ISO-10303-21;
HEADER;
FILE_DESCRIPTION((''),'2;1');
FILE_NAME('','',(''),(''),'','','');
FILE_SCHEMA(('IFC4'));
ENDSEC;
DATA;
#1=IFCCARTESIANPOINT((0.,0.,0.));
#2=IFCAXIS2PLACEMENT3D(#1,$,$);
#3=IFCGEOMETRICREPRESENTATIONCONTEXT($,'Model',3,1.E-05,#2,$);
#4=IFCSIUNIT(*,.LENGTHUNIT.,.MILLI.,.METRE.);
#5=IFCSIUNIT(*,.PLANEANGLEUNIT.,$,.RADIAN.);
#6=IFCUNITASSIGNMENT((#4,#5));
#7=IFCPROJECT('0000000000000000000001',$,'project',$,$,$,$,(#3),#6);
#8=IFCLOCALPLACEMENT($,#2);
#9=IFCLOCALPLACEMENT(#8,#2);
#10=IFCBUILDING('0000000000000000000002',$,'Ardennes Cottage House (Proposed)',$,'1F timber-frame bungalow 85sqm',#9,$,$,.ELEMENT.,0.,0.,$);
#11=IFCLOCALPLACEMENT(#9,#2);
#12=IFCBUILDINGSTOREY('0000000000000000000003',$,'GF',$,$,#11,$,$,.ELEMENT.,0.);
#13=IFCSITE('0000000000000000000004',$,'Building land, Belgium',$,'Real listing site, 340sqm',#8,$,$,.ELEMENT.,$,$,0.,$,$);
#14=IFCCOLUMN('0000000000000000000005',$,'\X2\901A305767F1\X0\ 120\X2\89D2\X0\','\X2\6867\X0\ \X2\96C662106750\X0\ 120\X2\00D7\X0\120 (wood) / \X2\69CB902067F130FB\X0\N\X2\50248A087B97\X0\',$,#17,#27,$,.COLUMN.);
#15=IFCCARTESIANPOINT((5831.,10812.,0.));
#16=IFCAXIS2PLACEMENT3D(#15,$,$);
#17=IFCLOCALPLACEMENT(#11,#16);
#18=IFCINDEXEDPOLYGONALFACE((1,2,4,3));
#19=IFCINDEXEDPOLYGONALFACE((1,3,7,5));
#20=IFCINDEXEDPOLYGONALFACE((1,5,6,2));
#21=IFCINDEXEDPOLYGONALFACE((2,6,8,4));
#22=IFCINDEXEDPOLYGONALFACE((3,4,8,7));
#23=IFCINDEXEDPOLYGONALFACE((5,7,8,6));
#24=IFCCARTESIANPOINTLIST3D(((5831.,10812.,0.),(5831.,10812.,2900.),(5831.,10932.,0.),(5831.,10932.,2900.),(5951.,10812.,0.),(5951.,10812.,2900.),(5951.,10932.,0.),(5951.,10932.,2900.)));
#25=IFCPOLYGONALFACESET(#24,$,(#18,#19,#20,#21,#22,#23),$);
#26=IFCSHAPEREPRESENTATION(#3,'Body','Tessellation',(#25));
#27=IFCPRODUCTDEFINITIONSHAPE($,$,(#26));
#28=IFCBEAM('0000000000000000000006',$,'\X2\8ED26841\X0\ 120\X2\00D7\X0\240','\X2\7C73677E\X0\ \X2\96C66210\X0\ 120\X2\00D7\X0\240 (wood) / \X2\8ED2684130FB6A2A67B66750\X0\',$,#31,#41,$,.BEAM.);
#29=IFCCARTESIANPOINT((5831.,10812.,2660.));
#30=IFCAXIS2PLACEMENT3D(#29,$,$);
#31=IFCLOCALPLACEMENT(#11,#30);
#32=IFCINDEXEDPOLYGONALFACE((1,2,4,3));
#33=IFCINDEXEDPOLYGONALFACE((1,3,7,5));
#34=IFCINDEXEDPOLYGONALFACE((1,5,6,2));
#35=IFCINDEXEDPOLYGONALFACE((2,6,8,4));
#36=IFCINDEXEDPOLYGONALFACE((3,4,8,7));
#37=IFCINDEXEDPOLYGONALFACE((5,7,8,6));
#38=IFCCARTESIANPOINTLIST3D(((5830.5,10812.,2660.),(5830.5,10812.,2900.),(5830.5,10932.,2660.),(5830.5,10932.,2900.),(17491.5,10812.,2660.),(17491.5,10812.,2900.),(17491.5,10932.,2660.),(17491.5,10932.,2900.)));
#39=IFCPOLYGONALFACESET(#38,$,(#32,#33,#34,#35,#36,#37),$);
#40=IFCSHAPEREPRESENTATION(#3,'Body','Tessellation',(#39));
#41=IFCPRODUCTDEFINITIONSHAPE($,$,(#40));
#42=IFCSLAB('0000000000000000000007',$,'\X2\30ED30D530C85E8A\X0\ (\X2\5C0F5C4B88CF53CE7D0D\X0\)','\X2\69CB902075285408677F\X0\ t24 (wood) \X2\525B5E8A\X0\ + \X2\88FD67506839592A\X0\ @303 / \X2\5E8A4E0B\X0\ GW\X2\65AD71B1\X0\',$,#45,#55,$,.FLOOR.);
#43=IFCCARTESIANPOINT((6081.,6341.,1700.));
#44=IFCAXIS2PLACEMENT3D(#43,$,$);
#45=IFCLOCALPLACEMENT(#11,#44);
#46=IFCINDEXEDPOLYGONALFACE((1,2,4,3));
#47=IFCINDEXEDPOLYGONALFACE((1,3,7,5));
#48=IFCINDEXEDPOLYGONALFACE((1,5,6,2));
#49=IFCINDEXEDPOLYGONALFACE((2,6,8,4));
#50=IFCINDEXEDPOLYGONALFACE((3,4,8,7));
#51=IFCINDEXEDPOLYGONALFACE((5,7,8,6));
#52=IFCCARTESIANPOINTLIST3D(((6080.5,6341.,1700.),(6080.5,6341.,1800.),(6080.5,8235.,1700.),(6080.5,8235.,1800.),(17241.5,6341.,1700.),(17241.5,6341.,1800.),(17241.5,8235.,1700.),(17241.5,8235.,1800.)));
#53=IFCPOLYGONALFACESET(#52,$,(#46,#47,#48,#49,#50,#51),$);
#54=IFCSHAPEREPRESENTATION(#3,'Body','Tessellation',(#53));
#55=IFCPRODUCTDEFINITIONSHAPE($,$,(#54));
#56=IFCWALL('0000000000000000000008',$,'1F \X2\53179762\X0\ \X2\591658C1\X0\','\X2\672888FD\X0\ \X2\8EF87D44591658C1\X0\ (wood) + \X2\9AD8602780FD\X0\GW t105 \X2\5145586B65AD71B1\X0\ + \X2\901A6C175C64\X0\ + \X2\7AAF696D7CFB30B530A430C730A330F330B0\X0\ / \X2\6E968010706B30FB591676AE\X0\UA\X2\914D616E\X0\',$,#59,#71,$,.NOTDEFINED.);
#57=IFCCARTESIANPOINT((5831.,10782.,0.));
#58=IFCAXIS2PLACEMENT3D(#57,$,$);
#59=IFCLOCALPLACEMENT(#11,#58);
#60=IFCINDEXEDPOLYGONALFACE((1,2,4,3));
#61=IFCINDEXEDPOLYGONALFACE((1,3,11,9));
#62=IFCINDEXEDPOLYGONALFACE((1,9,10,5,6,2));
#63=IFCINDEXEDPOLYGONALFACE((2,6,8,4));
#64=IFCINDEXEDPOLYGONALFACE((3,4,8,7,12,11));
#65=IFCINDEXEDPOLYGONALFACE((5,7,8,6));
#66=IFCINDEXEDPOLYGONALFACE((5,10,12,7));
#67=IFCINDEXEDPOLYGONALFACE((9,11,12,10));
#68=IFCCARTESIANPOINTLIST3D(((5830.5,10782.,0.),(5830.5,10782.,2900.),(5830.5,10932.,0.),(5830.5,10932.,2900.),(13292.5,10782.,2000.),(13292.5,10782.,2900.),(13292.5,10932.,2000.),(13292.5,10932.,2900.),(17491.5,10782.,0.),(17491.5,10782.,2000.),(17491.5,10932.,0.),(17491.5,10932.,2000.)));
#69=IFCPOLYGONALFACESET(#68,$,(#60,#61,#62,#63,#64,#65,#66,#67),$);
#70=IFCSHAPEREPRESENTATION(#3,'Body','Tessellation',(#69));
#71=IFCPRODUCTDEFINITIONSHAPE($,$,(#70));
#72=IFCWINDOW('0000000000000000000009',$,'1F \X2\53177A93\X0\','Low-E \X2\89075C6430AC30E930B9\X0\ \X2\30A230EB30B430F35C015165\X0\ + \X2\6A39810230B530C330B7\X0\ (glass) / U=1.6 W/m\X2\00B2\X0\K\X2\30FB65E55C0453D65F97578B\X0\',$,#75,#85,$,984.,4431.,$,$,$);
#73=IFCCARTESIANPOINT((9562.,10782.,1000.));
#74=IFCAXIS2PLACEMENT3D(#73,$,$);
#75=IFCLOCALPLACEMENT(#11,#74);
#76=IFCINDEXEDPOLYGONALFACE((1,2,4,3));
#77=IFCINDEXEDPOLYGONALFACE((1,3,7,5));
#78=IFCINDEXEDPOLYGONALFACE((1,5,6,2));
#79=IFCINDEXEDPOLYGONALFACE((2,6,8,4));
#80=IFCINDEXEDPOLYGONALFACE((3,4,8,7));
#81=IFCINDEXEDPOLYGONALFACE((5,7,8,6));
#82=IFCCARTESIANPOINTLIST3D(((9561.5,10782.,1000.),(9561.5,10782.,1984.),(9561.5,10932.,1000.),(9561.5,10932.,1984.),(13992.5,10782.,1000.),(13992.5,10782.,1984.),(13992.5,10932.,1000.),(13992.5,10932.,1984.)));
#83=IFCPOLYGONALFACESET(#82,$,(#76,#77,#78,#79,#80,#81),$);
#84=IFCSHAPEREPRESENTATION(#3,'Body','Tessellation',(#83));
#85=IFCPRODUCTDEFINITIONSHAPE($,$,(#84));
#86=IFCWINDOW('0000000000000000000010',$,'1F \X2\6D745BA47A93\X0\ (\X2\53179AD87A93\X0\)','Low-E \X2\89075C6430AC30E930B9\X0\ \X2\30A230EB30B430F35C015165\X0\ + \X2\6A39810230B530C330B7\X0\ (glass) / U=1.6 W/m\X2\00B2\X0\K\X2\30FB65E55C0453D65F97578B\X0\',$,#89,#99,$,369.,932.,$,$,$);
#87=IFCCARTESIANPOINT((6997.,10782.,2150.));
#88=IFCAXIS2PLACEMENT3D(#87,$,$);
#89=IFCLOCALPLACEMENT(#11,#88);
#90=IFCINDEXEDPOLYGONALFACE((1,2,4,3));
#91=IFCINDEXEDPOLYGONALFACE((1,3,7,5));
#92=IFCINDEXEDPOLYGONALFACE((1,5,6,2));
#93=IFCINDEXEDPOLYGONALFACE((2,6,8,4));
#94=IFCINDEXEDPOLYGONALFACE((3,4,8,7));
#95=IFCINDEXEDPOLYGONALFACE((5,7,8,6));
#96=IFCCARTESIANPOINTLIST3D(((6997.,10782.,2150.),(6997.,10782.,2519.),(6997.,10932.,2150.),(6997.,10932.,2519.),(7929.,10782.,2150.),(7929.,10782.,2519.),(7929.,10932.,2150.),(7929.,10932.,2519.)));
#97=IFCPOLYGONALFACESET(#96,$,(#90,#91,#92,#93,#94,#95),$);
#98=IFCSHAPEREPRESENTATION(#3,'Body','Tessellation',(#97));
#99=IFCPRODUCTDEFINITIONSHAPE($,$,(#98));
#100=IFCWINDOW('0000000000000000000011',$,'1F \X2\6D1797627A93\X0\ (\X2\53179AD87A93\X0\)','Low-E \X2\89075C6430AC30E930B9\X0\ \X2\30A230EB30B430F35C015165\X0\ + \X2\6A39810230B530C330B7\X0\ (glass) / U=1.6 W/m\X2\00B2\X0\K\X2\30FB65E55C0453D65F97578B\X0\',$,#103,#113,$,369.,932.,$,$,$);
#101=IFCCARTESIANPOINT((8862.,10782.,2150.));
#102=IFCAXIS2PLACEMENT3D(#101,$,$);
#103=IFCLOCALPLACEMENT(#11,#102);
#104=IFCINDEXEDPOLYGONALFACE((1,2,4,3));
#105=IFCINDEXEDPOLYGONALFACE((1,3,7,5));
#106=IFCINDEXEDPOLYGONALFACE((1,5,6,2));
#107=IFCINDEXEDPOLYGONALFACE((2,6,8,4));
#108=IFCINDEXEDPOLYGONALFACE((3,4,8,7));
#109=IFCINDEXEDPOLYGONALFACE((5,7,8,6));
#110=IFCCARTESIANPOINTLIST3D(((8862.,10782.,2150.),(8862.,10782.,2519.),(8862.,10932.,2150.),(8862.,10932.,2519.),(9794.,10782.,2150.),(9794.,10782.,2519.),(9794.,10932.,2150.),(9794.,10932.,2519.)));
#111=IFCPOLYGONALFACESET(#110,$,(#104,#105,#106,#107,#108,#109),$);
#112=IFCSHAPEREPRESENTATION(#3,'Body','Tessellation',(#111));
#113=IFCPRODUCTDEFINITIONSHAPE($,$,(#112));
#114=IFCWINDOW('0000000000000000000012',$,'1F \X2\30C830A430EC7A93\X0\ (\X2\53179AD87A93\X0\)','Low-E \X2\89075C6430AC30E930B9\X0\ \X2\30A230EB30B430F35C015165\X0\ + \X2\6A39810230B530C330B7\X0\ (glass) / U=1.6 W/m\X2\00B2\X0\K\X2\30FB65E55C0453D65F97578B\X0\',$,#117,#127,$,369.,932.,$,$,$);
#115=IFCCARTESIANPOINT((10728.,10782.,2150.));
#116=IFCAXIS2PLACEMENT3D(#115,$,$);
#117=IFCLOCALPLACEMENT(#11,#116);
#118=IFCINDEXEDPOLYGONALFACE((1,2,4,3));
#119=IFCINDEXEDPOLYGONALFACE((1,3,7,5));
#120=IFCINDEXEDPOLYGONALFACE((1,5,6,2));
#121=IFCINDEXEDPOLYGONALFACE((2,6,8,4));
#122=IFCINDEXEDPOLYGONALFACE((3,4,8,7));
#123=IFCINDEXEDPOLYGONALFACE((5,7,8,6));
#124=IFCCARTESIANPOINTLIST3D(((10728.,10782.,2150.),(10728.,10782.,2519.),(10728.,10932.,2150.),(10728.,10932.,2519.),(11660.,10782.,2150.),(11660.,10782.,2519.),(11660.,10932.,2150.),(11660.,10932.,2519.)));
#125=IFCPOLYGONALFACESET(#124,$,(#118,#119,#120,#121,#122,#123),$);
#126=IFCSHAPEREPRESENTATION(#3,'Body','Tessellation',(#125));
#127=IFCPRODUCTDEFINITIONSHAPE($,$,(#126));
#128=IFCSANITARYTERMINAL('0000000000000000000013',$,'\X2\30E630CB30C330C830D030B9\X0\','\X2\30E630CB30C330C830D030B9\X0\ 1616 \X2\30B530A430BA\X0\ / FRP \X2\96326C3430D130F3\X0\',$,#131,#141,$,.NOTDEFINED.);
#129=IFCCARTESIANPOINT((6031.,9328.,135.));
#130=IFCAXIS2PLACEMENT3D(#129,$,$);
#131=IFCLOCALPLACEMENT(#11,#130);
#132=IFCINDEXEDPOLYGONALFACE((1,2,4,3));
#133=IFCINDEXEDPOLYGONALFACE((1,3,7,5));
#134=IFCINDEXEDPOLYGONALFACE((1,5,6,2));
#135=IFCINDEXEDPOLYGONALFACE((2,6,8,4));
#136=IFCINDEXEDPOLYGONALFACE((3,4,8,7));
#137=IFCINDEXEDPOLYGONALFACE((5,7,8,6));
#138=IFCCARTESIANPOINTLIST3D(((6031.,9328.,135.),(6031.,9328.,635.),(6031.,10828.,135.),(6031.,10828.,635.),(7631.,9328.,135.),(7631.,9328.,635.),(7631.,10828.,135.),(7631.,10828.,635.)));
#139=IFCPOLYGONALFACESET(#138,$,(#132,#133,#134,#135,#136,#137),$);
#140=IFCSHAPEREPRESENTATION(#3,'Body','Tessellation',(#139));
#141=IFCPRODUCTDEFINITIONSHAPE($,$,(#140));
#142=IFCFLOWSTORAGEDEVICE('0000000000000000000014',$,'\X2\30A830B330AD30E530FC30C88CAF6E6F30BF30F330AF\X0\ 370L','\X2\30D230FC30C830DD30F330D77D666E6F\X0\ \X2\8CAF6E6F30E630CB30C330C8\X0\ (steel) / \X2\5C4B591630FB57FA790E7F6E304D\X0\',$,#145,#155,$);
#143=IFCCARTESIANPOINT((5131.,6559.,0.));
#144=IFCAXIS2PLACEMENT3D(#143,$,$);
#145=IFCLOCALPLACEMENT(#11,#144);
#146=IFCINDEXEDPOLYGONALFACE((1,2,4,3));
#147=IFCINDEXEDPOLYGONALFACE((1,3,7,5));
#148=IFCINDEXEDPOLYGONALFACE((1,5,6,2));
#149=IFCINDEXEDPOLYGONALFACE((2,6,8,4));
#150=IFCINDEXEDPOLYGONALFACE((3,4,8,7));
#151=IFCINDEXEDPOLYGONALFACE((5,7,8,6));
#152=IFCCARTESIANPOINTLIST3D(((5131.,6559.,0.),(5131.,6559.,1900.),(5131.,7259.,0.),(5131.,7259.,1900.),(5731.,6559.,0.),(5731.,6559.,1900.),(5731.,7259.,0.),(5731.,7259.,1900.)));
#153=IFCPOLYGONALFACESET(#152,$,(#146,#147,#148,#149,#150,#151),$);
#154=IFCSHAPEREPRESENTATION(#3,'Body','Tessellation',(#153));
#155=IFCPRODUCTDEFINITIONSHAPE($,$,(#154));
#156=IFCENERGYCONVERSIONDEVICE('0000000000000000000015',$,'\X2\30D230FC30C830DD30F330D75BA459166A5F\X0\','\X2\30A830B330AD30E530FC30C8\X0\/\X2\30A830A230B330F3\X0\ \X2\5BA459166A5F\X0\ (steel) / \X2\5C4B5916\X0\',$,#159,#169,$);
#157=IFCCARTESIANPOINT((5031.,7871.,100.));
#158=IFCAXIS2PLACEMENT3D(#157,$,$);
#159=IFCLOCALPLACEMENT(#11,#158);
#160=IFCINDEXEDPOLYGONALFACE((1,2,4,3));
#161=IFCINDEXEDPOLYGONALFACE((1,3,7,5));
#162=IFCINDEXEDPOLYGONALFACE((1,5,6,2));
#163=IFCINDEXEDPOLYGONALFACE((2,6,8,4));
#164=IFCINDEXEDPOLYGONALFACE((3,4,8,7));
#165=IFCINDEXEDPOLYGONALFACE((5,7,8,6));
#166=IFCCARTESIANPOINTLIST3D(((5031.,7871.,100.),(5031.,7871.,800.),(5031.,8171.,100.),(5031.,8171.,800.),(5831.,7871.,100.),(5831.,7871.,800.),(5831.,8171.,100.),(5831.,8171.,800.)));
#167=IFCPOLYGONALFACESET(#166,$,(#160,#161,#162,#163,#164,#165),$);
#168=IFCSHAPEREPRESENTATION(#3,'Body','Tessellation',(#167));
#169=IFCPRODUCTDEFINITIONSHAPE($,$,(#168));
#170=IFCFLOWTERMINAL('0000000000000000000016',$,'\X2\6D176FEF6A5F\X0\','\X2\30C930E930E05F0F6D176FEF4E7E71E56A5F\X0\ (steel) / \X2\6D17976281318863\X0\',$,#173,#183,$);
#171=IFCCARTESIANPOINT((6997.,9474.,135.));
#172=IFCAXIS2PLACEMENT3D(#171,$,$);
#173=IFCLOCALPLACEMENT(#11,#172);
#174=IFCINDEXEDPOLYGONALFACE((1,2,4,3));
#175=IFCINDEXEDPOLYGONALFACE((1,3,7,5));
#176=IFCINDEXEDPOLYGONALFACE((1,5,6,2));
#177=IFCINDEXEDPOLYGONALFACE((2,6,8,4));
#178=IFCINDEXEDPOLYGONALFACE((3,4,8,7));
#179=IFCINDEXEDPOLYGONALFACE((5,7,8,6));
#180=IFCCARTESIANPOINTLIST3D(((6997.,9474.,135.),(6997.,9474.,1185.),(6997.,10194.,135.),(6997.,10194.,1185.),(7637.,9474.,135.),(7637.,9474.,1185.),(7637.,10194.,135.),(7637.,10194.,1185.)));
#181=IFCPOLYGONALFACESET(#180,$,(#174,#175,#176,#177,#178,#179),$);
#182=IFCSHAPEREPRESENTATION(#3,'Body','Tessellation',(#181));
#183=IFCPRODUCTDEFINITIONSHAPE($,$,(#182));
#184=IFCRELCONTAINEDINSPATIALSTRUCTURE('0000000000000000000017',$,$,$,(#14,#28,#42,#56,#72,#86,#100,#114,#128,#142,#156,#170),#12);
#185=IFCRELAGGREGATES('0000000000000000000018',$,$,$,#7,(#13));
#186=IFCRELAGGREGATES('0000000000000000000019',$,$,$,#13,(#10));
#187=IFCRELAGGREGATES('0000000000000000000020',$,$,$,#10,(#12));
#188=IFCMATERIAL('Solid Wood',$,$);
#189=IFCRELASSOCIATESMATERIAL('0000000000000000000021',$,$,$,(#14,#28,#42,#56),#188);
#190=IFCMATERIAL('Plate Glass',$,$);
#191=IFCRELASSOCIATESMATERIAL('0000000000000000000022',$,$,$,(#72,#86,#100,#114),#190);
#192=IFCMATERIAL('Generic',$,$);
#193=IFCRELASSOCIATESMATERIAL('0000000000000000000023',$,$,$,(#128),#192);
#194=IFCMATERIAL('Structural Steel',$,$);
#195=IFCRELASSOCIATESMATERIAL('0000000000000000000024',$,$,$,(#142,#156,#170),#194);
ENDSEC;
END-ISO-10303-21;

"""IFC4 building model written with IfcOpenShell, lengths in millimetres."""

from ifc_helpers import new_model, si_unit, frame, frame_2d, origin, place, context, project, spatial, rectangle, extrude, material, element, fill, save


model = new_model("IFC4")

# Units and contexts
model_context = context("Model", 3, precision=1e-05, world=origin())
ifc_project = project(units=[si_unit("LENGTHUNIT", "METRE", prefix="MILLI"), si_unit("PLANEANGLEUNIT", "RADIAN")], contexts=[model_context])

# Site, building, storey
site_placement = place(None, origin())
site = spatial("IfcSite", under=ifc_project, at=site_placement, Name="Building land, Belgium", ObjectType="Real listing site, 340sqm", CompositionType="ELEMENT", RefElevation=0.0)
building_placement = place(site_placement, origin())
building = spatial("IfcBuilding", under=site, at=building_placement, Name="Ardennes Cottage House (Proposed)", ObjectType="1F timber-frame bungalow 85sqm", CompositionType="ELEMENT", ElevationOfRefHeight=0.0, ElevationOfTerrain=0.0)
storey_placement = place(building_placement, origin())
storey = spatial("IfcBuildingStorey", under=building, at=storey_placement, Name="GF", CompositionType="ELEMENT", Elevation=0.0)

# Column
ifc_material_1 = material(Name="Solid Wood")
column_1_placement = place(storey_placement, frame((5831.0, 10812.0, 0.0)))
element("IfcColumn", 1, at=column_1_placement, inside=storey, material=ifc_material_1, Name="通し柱 120角", Description="桧 集成材 120×120 (wood) / 構造柱・N値計算", PredefinedType="COLUMN", context=model_context, shape_type="SweptSolid", body=[
    extrude(rectangle(XDim=120.0, YDim=120.0, at=frame_2d((60.0, 60.0))), frame((5831.0, 10812.0, 0.0)), (0.0, 0.0, 1.0), 2900.0),
])

# Beam
beam_1_placement = place(storey_placement, frame((5831.0, 10812.0, 2660.0)))
element("IfcBeam", 2, at=beam_1_placement, inside=storey, material=ifc_material_1, Name="軒桁 120×240", Description="米松 集成 120×240 (wood) / 軒桁・横架材", PredefinedType="BEAM", context=model_context, shape_type="SweptSolid", body=[
    extrude(rectangle(XDim=11661.0, YDim=120.0, at=frame_2d((5830.0, 60.0))), frame((5831.0, 10812.0, 2660.0)), (0.0, 0.0, 1.0), 240.0),
])

# Slab
slab_placement = place(storey_placement, frame((6081.0, 6341.0, 1700.0)))
element("IfcSlab", 3, at=slab_placement, inside=storey, material=ifc_material_1, Name="ロフト床 (小屋裏収納)", Description="構造用合板 t24 (wood) 剛床 + 製材根太 @303 / 床下 GW断熱", PredefinedType="FLOOR", context=model_context, shape_type="SweptSolid", body=[
    extrude(rectangle(XDim=11161.0, YDim=1894.0, at=frame_2d((5580.0, 947.0))), frame((6081.0, 6341.0, 1700.0)), (0.0, 0.0, 1.0), 100.0),
])

# Wall, openings, windows
wall_1_placement = place(storey_placement, frame((5831.0, 10782.0, 0.0)))
wall_1 = element("IfcWall", 4, at=wall_1_placement, inside=storey, material=ifc_material_1, Name="1F 北面 外壁", Description="木製 軸組外壁 (wood) + 高性能GW t105 充填断熱 + 通気層 + 窯業系サイディング / 準耐火・外皮UA配慮", PredefinedType="NOTDEFINED", context=model_context, shape_type="SweptSolid", body=[
    extrude(rectangle(XDim=11661.0, YDim=150.0, at=frame_2d((5830.0, 75.0))), frame((5831.0, 10782.0, 0.0)), (0.0, 0.0, 1.0), 2900.0),
])
opening_1_placement = place(storey_placement, frame((9562.0, 10782.0, 1000.0)))
opening_1 = element("IfcOpeningElement", 5, at=opening_1_placement, cuts=wall_1, PredefinedType="NOTDEFINED", context=model_context, shape_type="SweptSolid", body=[
    extrude(rectangle(XDim=4431.0, YDim=150.0, at=frame_2d((2215.0, 75.0))), frame((9562.0, 10782.0, 1000.0)), (0.0, 0.0, 1.0), 984.0),
])
opening_2_placement = place(storey_placement, frame((6997.0, 10782.0, 2150.0)))
opening_2 = element("IfcOpeningElement", 6, at=opening_2_placement, cuts=wall_1, PredefinedType="NOTDEFINED", context=model_context, shape_type="SweptSolid", body=[
    extrude(rectangle(XDim=932.0, YDim=150.0, at=frame_2d((466.0, 75.0))), frame((6997.0, 10782.0, 2150.0)), (0.0, 0.0, 1.0), 369.0),
])
opening_3_placement = place(storey_placement, frame((8862.0, 10782.0, 2150.0)))
opening_3 = element("IfcOpeningElement", 7, at=opening_3_placement, cuts=wall_1, PredefinedType="NOTDEFINED", context=model_context, shape_type="SweptSolid", body=[
    extrude(rectangle(XDim=932.0, YDim=150.0, at=frame_2d((466.0, 75.0))), frame((8862.0, 10782.0, 2150.0)), (0.0, 0.0, 1.0), 369.0),
])
opening_4_placement = place(storey_placement, frame((10728.0, 10782.0, 2150.0)))
opening_4 = element("IfcOpeningElement", 8, at=opening_4_placement, cuts=wall_1, PredefinedType="NOTDEFINED", context=model_context, shape_type="SweptSolid", body=[
    extrude(rectangle(XDim=932.0, YDim=150.0, at=frame_2d((466.0, 75.0))), frame((10728.0, 10782.0, 2150.0)), (0.0, 0.0, 1.0), 369.0),
])
ifc_material_2 = material(Name="Plate Glass")
window_1_placement = place(storey_placement, frame((9562.0, 10782.0, 1000.0)))
window_1 = element("IfcWindow", 9, at=window_1_placement, inside=storey, material=ifc_material_2, Name="1F 北窓", Description="Low-E 複層ガラス アルゴン封入 + 樹脂サッシ (glass) / U=1.6 W/m²K・日射取得型", OverallHeight=984.0, OverallWidth=4431.0, context=model_context, shape_type="SweptSolid", body=[
    extrude(rectangle(XDim=4431.0, YDim=150.0, at=frame_2d((2215.0, 75.0))), frame((9562.0, 10782.0, 1000.0)), (0.0, 0.0, 1.0), 984.0),
])
fill(opening_1, window_1)
window_2_placement = place(storey_placement, frame((6997.0, 10782.0, 2150.0)))
window_2 = element("IfcWindow", 10, at=window_2_placement, inside=storey, material=ifc_material_2, Name="1F 浴室窓 (北高窓)", Description="Low-E 複層ガラス アルゴン封入 + 樹脂サッシ (glass) / U=1.6 W/m²K・日射取得型", OverallHeight=369.0, OverallWidth=932.0, context=model_context, shape_type="SweptSolid", body=[
    extrude(rectangle(XDim=932.0, YDim=150.0, at=frame_2d((466.0, 75.0))), frame((6997.0, 10782.0, 2150.0)), (0.0, 0.0, 1.0), 369.0),
])
fill(opening_2, window_2)
window_3_placement = place(storey_placement, frame((8862.0, 10782.0, 2150.0)))
window_3 = element("IfcWindow", 11, at=window_3_placement, inside=storey, material=ifc_material_2, Name="1F 洗面窓 (北高窓)", Description="Low-E 複層ガラス アルゴン封入 + 樹脂サッシ (glass) / U=1.6 W/m²K・日射取得型", OverallHeight=369.0, OverallWidth=932.0, context=model_context, shape_type="SweptSolid", body=[
    extrude(rectangle(XDim=932.0, YDim=150.0, at=frame_2d((466.0, 75.0))), frame((8862.0, 10782.0, 2150.0)), (0.0, 0.0, 1.0), 369.0),
])
fill(opening_3, window_3)
window_4_placement = place(storey_placement, frame((10728.0, 10782.0, 2150.0)))
window_4 = element("IfcWindow", 12, at=window_4_placement, inside=storey, material=ifc_material_2, Name="1F トイレ窓 (北高窓)", Description="Low-E 複層ガラス アルゴン封入 + 樹脂サッシ (glass) / U=1.6 W/m²K・日射取得型", OverallHeight=369.0, OverallWidth=932.0, context=model_context, shape_type="SweptSolid", body=[
    extrude(rectangle(XDim=932.0, YDim=150.0, at=frame_2d((466.0, 75.0))), frame((10728.0, 10782.0, 2150.0)), (0.0, 0.0, 1.0), 369.0),
])
fill(opening_4, window_4)

# Sanitary terminal
ifc_material_3 = material(Name="Generic")
sanitary_terminal_placement = place(storey_placement, frame((6031.0, 9328.0, 135.0)))
element("IfcSanitaryTerminal", 13, at=sanitary_terminal_placement, inside=storey, material=ifc_material_3, Name="ユニットバス", Description="ユニットバス 1616 サイズ / FRP 防水パン", PredefinedType="NOTDEFINED", context=model_context, shape_type="SweptSolid", body=[
    extrude(rectangle(XDim=1600.0, YDim=1500.0, at=frame_2d((800.0, 750.0))), frame((6031.0, 9328.0, 135.0)), (0.0, 0.0, 1.0), 500.0),
])

# Flow storage device
ifc_material_4 = material(Name="Structural Steel")
flow_storage_device_placement = place(storey_placement, frame((5131.0, 6559.0, 0.0)))
element("IfcFlowStorageDevice", 14, at=flow_storage_device_placement, inside=storey, material=ifc_material_4, Name="エコキュート貯湯タンク 370L", Description="ヒートポンプ給湯 貯湯ユニット (steel) / 屋外・基礎置き", context=model_context, shape_type="SweptSolid", body=[
    extrude(rectangle(XDim=600.0, YDim=700.0, at=frame_2d((300.0, 350.0))), frame((5131.0, 6559.0, 0.0)), (0.0, 0.0, 1.0), 1900.0),
])

# Energy conversion device
energy_conversion_device_placement = place(storey_placement, frame((5031.0, 7871.0, 100.0)))
element("IfcEnergyConversionDevice", 15, at=energy_conversion_device_placement, inside=storey, material=ifc_material_4, Name="ヒートポンプ室外機", Description="エコキュート/エアコン 室外機 (steel) / 屋外", context=model_context, shape_type="SweptSolid", body=[
    extrude(rectangle(XDim=800.0, YDim=300.0, at=frame_2d((400.0, 150.0))), frame((5031.0, 7871.0, 100.0)), (0.0, 0.0, 1.0), 700.0),
])

# Flow terminal
flow_terminal_placement = place(storey_placement, frame((6997.0, 9474.0, 135.0)))
element("IfcFlowTerminal", 16, at=flow_terminal_placement, inside=storey, material=ifc_material_4, Name="洗濯機", Description="ドラム式洗濯乾燥機 (steel) / 洗面脱衣", context=model_context, shape_type="SweptSolid", body=[
    extrude(rectangle(XDim=640.0, YDim=720.0, at=frame_2d((320.0, 360.0))), frame((6997.0, 9474.0, 135.0)), (0.0, 0.0, 1.0), 1050.0),
])

save(model, "model.ifc")
